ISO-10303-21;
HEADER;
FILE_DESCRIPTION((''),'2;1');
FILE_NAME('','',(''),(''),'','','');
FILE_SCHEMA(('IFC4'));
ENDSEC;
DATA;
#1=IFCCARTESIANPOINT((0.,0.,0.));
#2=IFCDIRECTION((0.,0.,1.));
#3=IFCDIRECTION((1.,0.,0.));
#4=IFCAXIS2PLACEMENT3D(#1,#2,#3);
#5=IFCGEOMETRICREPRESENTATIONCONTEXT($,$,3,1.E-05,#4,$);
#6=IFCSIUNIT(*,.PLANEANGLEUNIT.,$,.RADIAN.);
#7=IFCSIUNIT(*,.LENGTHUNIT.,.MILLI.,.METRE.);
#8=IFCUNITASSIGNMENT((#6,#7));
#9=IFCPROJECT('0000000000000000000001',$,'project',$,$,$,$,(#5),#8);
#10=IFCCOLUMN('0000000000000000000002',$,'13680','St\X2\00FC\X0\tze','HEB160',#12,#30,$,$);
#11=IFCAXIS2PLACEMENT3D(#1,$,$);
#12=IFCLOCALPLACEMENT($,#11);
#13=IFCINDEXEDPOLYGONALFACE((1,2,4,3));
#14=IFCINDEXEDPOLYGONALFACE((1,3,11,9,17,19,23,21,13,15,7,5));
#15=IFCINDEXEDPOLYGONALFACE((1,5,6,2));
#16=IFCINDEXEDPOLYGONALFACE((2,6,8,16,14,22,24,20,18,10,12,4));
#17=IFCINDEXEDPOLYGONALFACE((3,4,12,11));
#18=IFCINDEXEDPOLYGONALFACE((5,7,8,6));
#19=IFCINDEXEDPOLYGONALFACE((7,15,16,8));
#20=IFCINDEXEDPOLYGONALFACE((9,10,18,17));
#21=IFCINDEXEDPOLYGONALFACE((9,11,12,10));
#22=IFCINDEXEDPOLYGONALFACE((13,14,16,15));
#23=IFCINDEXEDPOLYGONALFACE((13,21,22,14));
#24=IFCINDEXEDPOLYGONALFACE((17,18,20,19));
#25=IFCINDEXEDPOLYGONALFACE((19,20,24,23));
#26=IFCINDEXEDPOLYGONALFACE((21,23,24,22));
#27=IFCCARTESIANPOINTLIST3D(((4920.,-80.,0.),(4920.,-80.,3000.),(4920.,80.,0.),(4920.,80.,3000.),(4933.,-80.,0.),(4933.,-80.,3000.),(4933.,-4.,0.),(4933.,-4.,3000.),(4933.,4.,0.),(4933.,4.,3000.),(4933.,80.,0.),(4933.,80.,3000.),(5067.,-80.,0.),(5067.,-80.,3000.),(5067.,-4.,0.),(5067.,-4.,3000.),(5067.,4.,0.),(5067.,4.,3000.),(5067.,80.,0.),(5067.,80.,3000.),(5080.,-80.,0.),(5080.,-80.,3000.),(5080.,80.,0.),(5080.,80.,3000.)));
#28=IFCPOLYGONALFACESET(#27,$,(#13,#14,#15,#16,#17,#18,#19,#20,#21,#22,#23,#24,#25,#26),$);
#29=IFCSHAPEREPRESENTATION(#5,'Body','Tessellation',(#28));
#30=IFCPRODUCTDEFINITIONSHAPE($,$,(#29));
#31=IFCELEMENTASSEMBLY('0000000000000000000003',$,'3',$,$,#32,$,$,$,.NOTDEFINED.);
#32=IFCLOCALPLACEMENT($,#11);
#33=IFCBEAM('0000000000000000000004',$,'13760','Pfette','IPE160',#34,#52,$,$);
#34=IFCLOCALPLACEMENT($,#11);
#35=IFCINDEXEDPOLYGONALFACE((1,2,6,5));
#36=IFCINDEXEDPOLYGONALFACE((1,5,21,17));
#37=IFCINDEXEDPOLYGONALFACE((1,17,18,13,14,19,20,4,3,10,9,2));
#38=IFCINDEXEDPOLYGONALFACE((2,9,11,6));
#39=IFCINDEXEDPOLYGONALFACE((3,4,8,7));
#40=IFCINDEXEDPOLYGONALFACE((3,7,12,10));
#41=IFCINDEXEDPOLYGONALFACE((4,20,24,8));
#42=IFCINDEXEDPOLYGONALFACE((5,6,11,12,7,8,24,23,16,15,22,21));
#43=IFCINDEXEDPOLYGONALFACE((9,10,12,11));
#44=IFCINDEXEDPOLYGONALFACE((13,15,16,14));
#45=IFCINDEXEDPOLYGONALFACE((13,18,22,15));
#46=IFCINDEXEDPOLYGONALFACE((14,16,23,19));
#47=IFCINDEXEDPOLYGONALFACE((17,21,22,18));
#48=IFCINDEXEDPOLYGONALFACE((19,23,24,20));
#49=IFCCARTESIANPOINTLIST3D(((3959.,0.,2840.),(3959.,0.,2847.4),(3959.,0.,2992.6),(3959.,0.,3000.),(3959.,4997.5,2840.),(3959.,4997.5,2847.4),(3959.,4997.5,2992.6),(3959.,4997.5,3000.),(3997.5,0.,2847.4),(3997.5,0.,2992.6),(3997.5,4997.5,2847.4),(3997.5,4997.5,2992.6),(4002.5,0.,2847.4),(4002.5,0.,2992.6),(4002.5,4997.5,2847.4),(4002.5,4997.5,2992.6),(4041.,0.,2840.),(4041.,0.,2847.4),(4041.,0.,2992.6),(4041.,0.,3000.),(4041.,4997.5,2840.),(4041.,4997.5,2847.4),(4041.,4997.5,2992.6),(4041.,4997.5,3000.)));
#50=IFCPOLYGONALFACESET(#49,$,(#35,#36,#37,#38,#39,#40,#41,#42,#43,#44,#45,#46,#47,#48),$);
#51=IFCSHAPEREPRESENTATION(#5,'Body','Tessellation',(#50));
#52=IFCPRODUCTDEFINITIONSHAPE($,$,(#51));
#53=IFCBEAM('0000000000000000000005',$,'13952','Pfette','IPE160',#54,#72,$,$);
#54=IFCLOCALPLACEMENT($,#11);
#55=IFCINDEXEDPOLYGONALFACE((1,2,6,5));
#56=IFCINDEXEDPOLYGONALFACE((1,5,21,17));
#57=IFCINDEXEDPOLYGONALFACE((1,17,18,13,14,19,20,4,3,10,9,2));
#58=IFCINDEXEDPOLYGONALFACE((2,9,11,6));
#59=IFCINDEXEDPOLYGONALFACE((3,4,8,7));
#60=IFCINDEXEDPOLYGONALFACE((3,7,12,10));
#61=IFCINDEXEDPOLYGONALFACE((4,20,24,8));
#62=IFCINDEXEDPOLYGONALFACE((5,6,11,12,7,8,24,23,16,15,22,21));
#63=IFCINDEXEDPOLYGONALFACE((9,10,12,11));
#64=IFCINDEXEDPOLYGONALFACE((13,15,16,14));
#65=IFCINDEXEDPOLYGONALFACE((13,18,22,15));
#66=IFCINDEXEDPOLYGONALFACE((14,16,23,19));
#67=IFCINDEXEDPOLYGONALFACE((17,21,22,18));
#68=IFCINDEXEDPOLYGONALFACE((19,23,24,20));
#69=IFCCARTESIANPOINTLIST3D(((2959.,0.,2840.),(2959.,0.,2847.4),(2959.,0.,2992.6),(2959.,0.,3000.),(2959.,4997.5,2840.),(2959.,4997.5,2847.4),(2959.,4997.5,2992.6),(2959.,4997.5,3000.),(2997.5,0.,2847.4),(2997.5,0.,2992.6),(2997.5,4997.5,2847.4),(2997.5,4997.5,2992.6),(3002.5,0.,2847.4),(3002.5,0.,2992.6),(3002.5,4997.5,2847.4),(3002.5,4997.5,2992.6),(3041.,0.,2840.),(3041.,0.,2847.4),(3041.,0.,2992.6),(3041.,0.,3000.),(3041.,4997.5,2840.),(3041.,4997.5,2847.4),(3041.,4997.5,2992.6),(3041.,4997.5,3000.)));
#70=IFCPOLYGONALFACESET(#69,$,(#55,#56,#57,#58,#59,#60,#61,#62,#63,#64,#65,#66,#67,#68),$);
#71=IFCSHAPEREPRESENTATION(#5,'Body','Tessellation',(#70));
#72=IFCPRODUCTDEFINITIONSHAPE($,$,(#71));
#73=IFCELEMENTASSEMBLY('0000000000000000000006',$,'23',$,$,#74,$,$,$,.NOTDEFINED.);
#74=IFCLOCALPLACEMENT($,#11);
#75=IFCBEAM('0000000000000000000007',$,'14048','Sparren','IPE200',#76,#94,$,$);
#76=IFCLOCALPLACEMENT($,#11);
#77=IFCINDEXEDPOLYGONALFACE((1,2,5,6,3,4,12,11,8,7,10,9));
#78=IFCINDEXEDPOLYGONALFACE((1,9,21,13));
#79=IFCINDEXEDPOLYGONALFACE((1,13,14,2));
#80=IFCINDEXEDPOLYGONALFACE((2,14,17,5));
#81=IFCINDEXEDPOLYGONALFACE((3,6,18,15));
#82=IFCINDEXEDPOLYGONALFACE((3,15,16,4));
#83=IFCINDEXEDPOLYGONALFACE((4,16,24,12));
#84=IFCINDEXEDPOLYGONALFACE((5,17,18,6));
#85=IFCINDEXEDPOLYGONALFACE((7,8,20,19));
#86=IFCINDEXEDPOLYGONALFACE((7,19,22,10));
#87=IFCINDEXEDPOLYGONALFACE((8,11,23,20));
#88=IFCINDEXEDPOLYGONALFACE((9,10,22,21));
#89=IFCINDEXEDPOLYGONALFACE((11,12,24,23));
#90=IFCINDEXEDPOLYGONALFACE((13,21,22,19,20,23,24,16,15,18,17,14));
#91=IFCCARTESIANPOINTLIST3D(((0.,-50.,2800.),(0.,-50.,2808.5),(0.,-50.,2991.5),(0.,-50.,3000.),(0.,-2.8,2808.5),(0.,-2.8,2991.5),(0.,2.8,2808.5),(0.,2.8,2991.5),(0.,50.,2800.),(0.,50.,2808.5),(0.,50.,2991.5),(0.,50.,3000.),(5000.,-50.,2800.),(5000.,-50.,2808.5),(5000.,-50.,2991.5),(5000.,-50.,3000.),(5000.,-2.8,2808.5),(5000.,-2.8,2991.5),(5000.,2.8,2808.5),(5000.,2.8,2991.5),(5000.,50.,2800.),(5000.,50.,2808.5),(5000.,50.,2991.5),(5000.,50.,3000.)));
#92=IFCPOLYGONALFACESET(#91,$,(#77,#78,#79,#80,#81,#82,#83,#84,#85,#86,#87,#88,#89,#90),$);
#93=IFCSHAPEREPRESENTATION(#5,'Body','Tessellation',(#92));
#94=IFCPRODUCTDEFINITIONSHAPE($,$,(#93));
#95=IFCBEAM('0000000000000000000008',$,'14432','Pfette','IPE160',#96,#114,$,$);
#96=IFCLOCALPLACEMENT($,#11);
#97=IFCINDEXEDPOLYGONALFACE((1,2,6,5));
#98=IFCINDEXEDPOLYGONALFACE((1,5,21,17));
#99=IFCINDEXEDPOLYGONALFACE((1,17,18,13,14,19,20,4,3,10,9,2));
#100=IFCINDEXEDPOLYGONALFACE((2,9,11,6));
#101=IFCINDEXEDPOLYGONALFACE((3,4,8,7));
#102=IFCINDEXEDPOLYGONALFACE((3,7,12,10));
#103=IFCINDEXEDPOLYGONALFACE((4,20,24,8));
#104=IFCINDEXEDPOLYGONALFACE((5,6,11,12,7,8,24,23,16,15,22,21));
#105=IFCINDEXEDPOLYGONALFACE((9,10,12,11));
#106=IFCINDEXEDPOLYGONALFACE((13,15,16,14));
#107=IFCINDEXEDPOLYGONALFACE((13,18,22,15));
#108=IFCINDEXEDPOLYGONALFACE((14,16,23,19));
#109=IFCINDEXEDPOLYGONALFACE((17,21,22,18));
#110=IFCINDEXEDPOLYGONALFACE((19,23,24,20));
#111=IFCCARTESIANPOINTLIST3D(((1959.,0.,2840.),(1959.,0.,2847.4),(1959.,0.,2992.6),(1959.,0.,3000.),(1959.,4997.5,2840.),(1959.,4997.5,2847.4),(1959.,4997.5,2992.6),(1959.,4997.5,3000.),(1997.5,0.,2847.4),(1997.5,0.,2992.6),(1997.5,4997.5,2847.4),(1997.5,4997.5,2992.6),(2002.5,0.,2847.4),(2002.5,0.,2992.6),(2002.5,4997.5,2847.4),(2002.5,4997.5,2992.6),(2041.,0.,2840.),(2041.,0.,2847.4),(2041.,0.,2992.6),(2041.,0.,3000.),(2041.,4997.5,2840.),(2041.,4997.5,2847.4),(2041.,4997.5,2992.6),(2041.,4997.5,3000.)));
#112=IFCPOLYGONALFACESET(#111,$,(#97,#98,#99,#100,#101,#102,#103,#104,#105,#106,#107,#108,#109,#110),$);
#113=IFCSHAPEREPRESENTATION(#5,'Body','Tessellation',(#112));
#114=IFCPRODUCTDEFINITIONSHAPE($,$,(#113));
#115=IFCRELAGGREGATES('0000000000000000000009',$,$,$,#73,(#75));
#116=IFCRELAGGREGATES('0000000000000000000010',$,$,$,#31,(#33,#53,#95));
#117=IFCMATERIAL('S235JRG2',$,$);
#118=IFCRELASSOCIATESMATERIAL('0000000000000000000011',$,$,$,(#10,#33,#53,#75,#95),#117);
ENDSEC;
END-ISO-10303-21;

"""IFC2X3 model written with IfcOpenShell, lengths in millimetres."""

from ifc_helpers import new_model, si_unit, frame, origin_with_axes, place, context, project, polyline, outline, extrude, material, element, aggregate, save


model = new_model("IFC2X3")

# Units and contexts
context_of_model = context(None, 3, precision=1e-05, world=origin_with_axes())
ifc_project = project(units=[si_unit("PLANEANGLEUNIT", "RADIAN"), si_unit("LENGTHUNIT", "METRE", prefix="MILLI")], contexts=[context_of_model])

# Column
ifc_material = material(Name="S235JRG2")
placement_1 = place(None, frame((5000.0, 0.0, 3000.0), z_axis=(1.0, 0.0, 0.0), x_axis=(0.0, 0.0, -1.0)))
column_placement = place(placement_1, origin_with_axes())
element("IfcColumn", 1, at=column_placement, material=ifc_material, Name="13680", Description="Stütze", ObjectType="HEB160", context=context_of_model, shape_type="SweptSolid", body=[
    extrude(outline(polyline([(80.0, -80.0), (80.0, -67.0), (4.0, -67.0), (4.0, 67.0), (80.0, 67.0), (80.0, 80.0), (-80.0, 80.0), (-80.0, 67.0), (-4.0, 67.0), (-4.0, -67.0), (-80.0, -67.0), (-80.0, -80.0), (80.0, -80.0), (80.0, -80.0)])), frame((0.0, 0.0, 0.0), z_axis=(1.0, 0.0, 0.0), x_axis=(0.0, 1.0, 0.0)), (0.0, 0.0, 1.0), 3000.0),
])

# Element assembly, beams
assembly_1_placement = place(None, frame((1000.0, 5002.5, 6000.0), z_axis=(0.0, 0.0, 1.0), x_axis=(0.0, 1.0, 0.0)))
assembly_1 = element("IfcElementAssembly", 2, at=assembly_1_placement, Name="3", PredefinedType="NOTDEFINED")
placement_2 = place(None, frame((4000.0, 0.0, 2920.0), z_axis=(0.0, 0.0, 1.0), x_axis=(0.0, 1.0, 0.0)))
beam_1_placement = place(placement_2, origin_with_axes())
beam_1 = element("IfcBeam", 3, at=beam_1_placement, material=ifc_material, Name="13760", Description="Pfette", ObjectType="IPE160", context=context_of_model, shape_type="SweptSolid", body=[
    extrude(outline(polyline([(41.0, -80.0), (41.0, -72.6), (2.5, -72.6), (2.5, 72.6), (41.0, 72.6), (41.0, 80.0), (-41.0, 80.0), (-41.0, 72.6), (-2.5, 72.6), (-2.5, -72.6), (-41.0, -72.6), (-41.0, -80.0), (41.0, -80.0), (41.0, -80.0)])), frame((0.0, 0.0, 0.0), z_axis=(1.0, 0.0, 0.0), x_axis=(0.0, 1.0, 0.0)), (0.0, 0.0, 1.0), 4997.5),
])
placement_3 = place(None, frame((3000.0, 0.0, 2920.0), z_axis=(0.0, 0.0, 1.0), x_axis=(0.0, 1.0, 0.0)))
beam_2_placement = place(placement_3, origin_with_axes())
beam_2 = element("IfcBeam", 4, at=beam_2_placement, material=ifc_material, Name="13952", Description="Pfette", ObjectType="IPE160", context=context_of_model, shape_type="SweptSolid", body=[
    extrude(outline(polyline([(41.0, -80.0), (41.0, -72.6), (2.5, -72.6), (2.5, 72.6), (41.0, 72.6), (41.0, 80.0), (-41.0, 80.0), (-41.0, 72.6), (-2.5, 72.6), (-2.5, -72.6), (-41.0, -72.6), (-41.0, -80.0), (41.0, -80.0), (41.0, -80.0)])), frame((0.0, 0.0, 0.0), z_axis=(1.0, 0.0, 0.0), x_axis=(0.0, 1.0, 0.0)), (0.0, 0.0, 1.0), 4997.5),
])

# Element assembly, beam
assembly_2_placement = place(None, frame((5000.0, 0.0, 3000.0), z_axis=(0.0, 0.0, 1.0), x_axis=(-1.0, 0.0, 0.0)))
assembly_2 = element("IfcElementAssembly", 5, at=assembly_2_placement, Name="23", PredefinedType="NOTDEFINED")
placement_4 = place(None, frame((5000.0, 0.0, 2900.0), z_axis=(0.0, 0.0, 1.0), x_axis=(-1.0, 0.0, 0.0)))
beam_3_placement = place(placement_4, origin_with_axes())
beam_3 = element("IfcBeam", 6, at=beam_3_placement, material=ifc_material, Name="14048", Description="Sparren", ObjectType="IPE200", context=context_of_model, shape_type="SweptSolid", body=[
    extrude(outline(polyline([(50.0, -100.0), (50.0, -91.5), (2.8, -91.5), (2.8, 91.5), (50.0, 91.5), (50.0, 100.0), (-50.0, 100.0), (-50.0, 91.5), (-2.8, 91.5), (-2.8, -91.5), (-50.0, -91.5), (-50.0, -100.0), (50.0, -100.0), (50.0, -100.0)])), frame((0.0, 0.0, 0.0), z_axis=(1.0, 0.0, 0.0), x_axis=(0.0, 1.0, 0.0)), (0.0, 0.0, 1.0), 5000.0),
])
aggregate(assembly_2, [beam_3])

# Beam
placement_5 = place(None, frame((2000.0, 0.0, 2920.0), z_axis=(0.0, 0.0, 1.0), x_axis=(0.0, 1.0, 0.0)))
beam_4_placement = place(placement_5, origin_with_axes())
beam_4 = element("IfcBeam", 7, at=beam_4_placement, material=ifc_material, Name="14432", Description="Pfette", ObjectType="IPE160", context=context_of_model, shape_type="SweptSolid", body=[
    extrude(outline(polyline([(41.0, -80.0), (41.0, -72.6), (2.5, -72.6), (2.5, 72.6), (41.0, 72.6), (41.0, 80.0), (-41.0, 80.0), (-41.0, 72.6), (-2.5, 72.6), (-2.5, -72.6), (-41.0, -72.6), (-41.0, -80.0), (41.0, -80.0), (41.0, -80.0)])), frame((0.0, 0.0, 0.0), z_axis=(1.0, 0.0, 0.0), x_axis=(0.0, 1.0, 0.0)), (0.0, 0.0, 1.0), 4997.5),
])
aggregate(assembly_1, [beam_1, beam_2, beam_4])

save(model, "model.ifc")
